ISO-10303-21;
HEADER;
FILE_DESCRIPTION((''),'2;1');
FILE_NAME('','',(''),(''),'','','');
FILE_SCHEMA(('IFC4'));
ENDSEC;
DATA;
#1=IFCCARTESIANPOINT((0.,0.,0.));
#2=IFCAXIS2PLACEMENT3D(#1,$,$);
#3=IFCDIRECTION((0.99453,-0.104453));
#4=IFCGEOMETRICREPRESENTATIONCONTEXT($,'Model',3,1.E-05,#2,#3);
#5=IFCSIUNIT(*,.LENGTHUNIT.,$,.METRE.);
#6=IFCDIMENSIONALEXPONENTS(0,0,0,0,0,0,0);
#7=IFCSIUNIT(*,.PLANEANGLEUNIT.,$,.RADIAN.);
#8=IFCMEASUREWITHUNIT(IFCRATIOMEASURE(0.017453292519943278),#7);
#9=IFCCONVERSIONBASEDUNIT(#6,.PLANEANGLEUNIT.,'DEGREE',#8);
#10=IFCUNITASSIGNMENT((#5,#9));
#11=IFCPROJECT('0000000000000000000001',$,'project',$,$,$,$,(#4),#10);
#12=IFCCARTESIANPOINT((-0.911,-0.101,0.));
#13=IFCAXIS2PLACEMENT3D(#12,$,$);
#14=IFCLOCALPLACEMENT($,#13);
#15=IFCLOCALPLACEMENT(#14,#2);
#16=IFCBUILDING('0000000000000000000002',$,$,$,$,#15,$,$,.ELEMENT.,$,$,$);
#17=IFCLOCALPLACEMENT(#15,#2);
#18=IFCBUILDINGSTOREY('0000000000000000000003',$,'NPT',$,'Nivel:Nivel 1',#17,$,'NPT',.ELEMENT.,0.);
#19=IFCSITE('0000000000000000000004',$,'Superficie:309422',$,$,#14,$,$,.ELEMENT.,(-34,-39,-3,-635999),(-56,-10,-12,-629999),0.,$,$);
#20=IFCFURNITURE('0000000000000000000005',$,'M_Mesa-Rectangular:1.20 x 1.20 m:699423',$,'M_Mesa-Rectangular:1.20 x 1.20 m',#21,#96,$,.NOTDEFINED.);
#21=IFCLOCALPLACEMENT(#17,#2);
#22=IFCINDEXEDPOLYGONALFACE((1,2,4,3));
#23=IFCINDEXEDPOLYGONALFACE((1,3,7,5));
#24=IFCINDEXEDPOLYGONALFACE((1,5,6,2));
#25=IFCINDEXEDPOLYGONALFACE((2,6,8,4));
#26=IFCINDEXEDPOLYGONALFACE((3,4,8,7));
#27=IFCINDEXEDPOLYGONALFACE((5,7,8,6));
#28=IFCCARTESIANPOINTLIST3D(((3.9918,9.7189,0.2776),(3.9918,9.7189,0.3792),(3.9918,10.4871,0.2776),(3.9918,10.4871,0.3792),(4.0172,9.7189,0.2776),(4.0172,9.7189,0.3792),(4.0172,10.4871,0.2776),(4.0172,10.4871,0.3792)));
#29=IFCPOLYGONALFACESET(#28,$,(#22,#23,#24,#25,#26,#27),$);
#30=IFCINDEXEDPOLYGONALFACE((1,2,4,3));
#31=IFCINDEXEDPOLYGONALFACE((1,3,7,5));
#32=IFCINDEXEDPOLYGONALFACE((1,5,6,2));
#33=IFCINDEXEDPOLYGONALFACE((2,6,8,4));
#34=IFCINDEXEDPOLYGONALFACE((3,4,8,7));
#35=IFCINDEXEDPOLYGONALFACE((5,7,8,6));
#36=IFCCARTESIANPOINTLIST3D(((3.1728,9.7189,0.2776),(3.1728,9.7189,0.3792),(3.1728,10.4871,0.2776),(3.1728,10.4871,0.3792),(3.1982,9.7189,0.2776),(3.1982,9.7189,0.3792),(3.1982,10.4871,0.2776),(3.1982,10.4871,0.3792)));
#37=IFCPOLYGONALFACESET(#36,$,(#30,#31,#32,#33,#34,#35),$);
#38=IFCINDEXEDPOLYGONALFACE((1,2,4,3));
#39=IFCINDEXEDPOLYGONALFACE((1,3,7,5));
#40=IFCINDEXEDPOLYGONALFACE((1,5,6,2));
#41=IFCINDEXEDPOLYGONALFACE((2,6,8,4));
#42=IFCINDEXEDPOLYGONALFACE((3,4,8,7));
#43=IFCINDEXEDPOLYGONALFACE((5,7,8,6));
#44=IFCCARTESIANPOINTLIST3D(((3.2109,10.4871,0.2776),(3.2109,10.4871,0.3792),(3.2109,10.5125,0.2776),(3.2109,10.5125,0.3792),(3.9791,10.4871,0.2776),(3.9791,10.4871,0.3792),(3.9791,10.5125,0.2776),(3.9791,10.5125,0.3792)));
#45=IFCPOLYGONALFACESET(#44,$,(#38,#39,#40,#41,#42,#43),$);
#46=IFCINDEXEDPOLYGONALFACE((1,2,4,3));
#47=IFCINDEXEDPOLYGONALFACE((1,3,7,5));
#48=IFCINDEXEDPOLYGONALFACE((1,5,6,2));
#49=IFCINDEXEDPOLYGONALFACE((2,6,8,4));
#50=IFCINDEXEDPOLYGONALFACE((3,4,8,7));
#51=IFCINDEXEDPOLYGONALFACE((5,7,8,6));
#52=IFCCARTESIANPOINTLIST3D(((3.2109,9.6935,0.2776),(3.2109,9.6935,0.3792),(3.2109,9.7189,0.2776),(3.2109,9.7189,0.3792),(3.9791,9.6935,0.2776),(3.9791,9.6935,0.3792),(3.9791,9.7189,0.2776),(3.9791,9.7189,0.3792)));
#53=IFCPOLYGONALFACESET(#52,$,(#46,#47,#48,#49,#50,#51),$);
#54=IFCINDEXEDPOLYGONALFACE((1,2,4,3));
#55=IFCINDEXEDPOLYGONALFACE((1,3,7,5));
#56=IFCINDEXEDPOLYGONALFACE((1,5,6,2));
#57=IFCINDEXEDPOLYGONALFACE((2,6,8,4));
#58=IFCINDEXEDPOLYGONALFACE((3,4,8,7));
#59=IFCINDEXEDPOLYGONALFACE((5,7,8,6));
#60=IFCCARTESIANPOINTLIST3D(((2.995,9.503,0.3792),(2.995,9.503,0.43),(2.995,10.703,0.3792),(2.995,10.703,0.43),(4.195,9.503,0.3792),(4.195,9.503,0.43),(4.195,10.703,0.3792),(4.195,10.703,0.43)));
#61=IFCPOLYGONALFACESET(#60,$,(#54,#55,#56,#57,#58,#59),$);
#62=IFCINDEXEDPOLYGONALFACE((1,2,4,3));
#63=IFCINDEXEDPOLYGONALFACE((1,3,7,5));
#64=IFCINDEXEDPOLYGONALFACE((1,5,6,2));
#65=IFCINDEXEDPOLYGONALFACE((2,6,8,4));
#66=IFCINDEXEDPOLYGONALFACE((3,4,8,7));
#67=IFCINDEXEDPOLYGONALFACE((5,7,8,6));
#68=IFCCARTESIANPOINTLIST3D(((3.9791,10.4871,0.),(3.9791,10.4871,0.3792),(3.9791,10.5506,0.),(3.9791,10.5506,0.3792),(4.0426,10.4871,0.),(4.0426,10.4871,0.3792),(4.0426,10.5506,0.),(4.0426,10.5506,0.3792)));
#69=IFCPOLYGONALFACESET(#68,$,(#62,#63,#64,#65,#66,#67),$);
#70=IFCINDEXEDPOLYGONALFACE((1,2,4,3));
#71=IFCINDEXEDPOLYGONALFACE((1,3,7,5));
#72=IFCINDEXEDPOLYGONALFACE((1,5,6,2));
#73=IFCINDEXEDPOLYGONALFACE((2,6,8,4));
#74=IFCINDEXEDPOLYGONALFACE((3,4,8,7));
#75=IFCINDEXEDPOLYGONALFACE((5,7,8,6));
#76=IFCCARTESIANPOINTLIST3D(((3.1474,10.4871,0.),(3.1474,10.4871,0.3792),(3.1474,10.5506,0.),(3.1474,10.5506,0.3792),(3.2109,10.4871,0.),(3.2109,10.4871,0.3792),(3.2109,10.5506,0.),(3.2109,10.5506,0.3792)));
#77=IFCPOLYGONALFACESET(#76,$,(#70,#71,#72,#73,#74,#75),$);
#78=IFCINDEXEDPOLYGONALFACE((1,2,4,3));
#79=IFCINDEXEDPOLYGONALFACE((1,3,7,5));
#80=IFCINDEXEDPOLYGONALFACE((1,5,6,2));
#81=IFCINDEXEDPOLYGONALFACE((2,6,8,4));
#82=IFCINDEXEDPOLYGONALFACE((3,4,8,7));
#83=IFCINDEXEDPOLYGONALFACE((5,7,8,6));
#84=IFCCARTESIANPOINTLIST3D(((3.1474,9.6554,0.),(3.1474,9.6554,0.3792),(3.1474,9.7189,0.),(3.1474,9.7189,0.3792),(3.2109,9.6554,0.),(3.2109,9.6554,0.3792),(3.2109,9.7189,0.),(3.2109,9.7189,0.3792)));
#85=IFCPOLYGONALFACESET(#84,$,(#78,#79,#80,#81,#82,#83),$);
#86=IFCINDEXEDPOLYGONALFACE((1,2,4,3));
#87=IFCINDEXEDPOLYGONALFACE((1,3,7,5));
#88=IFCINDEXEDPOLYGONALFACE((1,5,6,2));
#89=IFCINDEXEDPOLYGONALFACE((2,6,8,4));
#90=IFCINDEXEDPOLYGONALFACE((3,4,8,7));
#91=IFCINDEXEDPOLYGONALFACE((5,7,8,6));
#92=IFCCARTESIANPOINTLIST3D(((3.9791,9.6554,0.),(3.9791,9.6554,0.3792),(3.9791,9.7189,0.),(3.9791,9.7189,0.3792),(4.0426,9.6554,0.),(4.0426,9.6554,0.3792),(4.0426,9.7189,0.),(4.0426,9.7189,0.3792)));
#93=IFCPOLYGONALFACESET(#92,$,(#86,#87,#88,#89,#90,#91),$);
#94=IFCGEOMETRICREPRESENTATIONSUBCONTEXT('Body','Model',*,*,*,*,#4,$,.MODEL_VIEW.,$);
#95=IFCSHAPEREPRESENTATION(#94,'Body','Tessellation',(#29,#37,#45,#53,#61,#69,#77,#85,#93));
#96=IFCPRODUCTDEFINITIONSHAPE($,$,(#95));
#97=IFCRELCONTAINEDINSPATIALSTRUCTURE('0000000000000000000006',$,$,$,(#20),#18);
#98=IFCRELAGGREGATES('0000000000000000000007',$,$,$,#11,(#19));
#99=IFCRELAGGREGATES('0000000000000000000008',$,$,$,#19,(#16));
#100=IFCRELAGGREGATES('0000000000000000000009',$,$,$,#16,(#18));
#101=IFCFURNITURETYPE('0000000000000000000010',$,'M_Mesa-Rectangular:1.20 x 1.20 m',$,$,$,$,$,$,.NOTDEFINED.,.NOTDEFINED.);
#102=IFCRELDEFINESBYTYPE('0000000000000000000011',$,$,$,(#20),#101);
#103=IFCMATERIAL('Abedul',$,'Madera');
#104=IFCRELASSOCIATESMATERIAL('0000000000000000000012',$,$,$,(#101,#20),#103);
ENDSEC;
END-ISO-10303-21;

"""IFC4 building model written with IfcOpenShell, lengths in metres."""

from ifc_helpers import new_model, entity, si_unit, converted_unit, direction, frame, frame_2d, origin, origin_2d_with_axis, place, context, subcontext, project, spatial, rectangle, extrude, source, transform, mapped, material, type_object, type_shapes, element, save


model = new_model("IFC4")

# Units and contexts
model_context = context("Model", 3, precision=1e-05, world=origin(), true_north=direction((0.99453, -0.104453)))
body_context = subcontext(model_context, "Body", "Model", "MODEL_VIEW")
ifc_project = project(units=[si_unit("LENGTHUNIT", "METRE"), converted_unit("PLANEANGLEUNIT", "DEGREE", entity("IfcRatioMeasure", 0.017453292519943278), si_unit("PLANEANGLEUNIT", "RADIAN"), dimensions=[0, 0, 0, 0, 0, 0, 0])], contexts=[model_context])

# Site, building, storey
site_placement = place(None, frame((-0.911, -0.101, 0.0)))
site = spatial("IfcSite", under=ifc_project, at=site_placement, Name="Superficie:309422", CompositionType="ELEMENT", RefLatitude=(-34, -39, -3, -635999), RefLongitude=(-56, -10, -12, -629999), RefElevation=0.0)
building_placement = place(site_placement, origin())
building = spatial("IfcBuilding", under=site, at=building_placement, CompositionType="ELEMENT")
storey_placement = place(building_placement, origin())
storey = spatial("IfcBuildingStorey", under=building, at=storey_placement, Name="NPT", ObjectType="Nivel:Nivel 1", LongName="NPT", CompositionType="ELEMENT", Elevation=0.0)

# Furniture
ifc_material_1 = material(Name="Abedul", Category="Madera")
furniture_type_1 = type_object("IfcFurnitureType", Name="M_Mesa-Rectangular:1.20 x 1.20 m", AssemblyPlace="NOTDEFINED", PredefinedType="NOTDEFINED", material=ifc_material_1)
shared_shape_1 = source(origin(), body_context, "Body", "SweptSolid", [
    extrude(rectangle(XDim=0.0254, YDim=0.7682, at=origin_2d_with_axis()), frame((0.4095, 0.0, 0.2776)), (0.0, 0.0, 1.0), 0.1016),
    extrude(rectangle(XDim=0.7682, YDim=0.0254, at=origin_2d_with_axis()), frame((-0.4095, 0.0, 0.2776), z_axis=(0.0, 0.0, 1.0), x_axis=(0.0, 1.0, 0.0)), (0.0, 0.0, 1.0), 0.1016),
    extrude(rectangle(XDim=0.7682, YDim=0.0254, at=frame_2d((0.0, 0.0), x_axis=(1.0, 0.0))), frame((0.0, 0.3968, 0.2776), z_axis=(0.0, 0.0, 1.0), x_axis=(-1.0, 0.0, 0.0)), (0.0, 0.0, 1.0), 0.1016),
    extrude(rectangle(XDim=0.0254, YDim=0.7682, at=origin_2d_with_axis()), frame((0.0, -0.3968, 0.2776), z_axis=(0.0, 0.0, 1.0), x_axis=(0.0, 1.0, 0.0)), (0.0, 0.0, 1.0), 0.1016),
    extrude(rectangle(XDim=1.2, YDim=1.2, at=origin_2d_with_axis()), frame((0.0, 0.0, 0.3792), z_axis=(0.0, 0.0, 1.0), x_axis=(-1.0, 0.0, 0.0)), (0.0, 0.0, 1.0), 0.0508),
    extrude(rectangle(XDim=0.0635, YDim=0.0635, at=origin_2d_with_axis()), frame((0.4158, 0.4159, 0.0), z_axis=(0.0, 0.0, 1.0), x_axis=(0.0, -1.0, 0.0)), (0.0, 0.0, 1.0), 0.3792),
    extrude(rectangle(XDim=0.0635, YDim=0.0635, at=origin_2d_with_axis()), frame((-0.4158, 0.4159, 0.0), z_axis=(0.0, 0.0, 1.0), x_axis=(-1.0, 0.0, 0.0)), (0.0, 0.0, 1.0), 0.3792),
    extrude(rectangle(XDim=0.0635, YDim=0.0635, at=origin_2d_with_axis()), frame((-0.4158, -0.4159, 0.0), z_axis=(0.0, 0.0, 1.0), x_axis=(0.0, 1.0, 0.0)), (0.0, 0.0, 1.0), 0.3792),
    extrude(rectangle(XDim=0.0635, YDim=0.0635, at=origin_2d_with_axis()), frame((0.4158, -0.4159, 0.0)), (0.0, 0.0, 1.0), 0.3792),
])
type_shapes(furniture_type_1, [shared_shape_1])
furniture_1_placement = place(storey_placement, frame((3.595, 10.103, 0.0)))
element("IfcFurniture", 1, at=furniture_1_placement, inside=storey, type_object=furniture_type_1, material=ifc_material_1, Name="M_Mesa-Rectangular:1.20 x 1.20 m:699423", ObjectType="M_Mesa-Rectangular:1.20 x 1.20 m", PredefinedType="NOTDEFINED", context=body_context, shape_type="MappedRepresentation", body=[
    mapped(shared_shape_1, transform((0.0, 0.0, 0.0), scale=1.0)),
])

save(model, "model.ifc")
